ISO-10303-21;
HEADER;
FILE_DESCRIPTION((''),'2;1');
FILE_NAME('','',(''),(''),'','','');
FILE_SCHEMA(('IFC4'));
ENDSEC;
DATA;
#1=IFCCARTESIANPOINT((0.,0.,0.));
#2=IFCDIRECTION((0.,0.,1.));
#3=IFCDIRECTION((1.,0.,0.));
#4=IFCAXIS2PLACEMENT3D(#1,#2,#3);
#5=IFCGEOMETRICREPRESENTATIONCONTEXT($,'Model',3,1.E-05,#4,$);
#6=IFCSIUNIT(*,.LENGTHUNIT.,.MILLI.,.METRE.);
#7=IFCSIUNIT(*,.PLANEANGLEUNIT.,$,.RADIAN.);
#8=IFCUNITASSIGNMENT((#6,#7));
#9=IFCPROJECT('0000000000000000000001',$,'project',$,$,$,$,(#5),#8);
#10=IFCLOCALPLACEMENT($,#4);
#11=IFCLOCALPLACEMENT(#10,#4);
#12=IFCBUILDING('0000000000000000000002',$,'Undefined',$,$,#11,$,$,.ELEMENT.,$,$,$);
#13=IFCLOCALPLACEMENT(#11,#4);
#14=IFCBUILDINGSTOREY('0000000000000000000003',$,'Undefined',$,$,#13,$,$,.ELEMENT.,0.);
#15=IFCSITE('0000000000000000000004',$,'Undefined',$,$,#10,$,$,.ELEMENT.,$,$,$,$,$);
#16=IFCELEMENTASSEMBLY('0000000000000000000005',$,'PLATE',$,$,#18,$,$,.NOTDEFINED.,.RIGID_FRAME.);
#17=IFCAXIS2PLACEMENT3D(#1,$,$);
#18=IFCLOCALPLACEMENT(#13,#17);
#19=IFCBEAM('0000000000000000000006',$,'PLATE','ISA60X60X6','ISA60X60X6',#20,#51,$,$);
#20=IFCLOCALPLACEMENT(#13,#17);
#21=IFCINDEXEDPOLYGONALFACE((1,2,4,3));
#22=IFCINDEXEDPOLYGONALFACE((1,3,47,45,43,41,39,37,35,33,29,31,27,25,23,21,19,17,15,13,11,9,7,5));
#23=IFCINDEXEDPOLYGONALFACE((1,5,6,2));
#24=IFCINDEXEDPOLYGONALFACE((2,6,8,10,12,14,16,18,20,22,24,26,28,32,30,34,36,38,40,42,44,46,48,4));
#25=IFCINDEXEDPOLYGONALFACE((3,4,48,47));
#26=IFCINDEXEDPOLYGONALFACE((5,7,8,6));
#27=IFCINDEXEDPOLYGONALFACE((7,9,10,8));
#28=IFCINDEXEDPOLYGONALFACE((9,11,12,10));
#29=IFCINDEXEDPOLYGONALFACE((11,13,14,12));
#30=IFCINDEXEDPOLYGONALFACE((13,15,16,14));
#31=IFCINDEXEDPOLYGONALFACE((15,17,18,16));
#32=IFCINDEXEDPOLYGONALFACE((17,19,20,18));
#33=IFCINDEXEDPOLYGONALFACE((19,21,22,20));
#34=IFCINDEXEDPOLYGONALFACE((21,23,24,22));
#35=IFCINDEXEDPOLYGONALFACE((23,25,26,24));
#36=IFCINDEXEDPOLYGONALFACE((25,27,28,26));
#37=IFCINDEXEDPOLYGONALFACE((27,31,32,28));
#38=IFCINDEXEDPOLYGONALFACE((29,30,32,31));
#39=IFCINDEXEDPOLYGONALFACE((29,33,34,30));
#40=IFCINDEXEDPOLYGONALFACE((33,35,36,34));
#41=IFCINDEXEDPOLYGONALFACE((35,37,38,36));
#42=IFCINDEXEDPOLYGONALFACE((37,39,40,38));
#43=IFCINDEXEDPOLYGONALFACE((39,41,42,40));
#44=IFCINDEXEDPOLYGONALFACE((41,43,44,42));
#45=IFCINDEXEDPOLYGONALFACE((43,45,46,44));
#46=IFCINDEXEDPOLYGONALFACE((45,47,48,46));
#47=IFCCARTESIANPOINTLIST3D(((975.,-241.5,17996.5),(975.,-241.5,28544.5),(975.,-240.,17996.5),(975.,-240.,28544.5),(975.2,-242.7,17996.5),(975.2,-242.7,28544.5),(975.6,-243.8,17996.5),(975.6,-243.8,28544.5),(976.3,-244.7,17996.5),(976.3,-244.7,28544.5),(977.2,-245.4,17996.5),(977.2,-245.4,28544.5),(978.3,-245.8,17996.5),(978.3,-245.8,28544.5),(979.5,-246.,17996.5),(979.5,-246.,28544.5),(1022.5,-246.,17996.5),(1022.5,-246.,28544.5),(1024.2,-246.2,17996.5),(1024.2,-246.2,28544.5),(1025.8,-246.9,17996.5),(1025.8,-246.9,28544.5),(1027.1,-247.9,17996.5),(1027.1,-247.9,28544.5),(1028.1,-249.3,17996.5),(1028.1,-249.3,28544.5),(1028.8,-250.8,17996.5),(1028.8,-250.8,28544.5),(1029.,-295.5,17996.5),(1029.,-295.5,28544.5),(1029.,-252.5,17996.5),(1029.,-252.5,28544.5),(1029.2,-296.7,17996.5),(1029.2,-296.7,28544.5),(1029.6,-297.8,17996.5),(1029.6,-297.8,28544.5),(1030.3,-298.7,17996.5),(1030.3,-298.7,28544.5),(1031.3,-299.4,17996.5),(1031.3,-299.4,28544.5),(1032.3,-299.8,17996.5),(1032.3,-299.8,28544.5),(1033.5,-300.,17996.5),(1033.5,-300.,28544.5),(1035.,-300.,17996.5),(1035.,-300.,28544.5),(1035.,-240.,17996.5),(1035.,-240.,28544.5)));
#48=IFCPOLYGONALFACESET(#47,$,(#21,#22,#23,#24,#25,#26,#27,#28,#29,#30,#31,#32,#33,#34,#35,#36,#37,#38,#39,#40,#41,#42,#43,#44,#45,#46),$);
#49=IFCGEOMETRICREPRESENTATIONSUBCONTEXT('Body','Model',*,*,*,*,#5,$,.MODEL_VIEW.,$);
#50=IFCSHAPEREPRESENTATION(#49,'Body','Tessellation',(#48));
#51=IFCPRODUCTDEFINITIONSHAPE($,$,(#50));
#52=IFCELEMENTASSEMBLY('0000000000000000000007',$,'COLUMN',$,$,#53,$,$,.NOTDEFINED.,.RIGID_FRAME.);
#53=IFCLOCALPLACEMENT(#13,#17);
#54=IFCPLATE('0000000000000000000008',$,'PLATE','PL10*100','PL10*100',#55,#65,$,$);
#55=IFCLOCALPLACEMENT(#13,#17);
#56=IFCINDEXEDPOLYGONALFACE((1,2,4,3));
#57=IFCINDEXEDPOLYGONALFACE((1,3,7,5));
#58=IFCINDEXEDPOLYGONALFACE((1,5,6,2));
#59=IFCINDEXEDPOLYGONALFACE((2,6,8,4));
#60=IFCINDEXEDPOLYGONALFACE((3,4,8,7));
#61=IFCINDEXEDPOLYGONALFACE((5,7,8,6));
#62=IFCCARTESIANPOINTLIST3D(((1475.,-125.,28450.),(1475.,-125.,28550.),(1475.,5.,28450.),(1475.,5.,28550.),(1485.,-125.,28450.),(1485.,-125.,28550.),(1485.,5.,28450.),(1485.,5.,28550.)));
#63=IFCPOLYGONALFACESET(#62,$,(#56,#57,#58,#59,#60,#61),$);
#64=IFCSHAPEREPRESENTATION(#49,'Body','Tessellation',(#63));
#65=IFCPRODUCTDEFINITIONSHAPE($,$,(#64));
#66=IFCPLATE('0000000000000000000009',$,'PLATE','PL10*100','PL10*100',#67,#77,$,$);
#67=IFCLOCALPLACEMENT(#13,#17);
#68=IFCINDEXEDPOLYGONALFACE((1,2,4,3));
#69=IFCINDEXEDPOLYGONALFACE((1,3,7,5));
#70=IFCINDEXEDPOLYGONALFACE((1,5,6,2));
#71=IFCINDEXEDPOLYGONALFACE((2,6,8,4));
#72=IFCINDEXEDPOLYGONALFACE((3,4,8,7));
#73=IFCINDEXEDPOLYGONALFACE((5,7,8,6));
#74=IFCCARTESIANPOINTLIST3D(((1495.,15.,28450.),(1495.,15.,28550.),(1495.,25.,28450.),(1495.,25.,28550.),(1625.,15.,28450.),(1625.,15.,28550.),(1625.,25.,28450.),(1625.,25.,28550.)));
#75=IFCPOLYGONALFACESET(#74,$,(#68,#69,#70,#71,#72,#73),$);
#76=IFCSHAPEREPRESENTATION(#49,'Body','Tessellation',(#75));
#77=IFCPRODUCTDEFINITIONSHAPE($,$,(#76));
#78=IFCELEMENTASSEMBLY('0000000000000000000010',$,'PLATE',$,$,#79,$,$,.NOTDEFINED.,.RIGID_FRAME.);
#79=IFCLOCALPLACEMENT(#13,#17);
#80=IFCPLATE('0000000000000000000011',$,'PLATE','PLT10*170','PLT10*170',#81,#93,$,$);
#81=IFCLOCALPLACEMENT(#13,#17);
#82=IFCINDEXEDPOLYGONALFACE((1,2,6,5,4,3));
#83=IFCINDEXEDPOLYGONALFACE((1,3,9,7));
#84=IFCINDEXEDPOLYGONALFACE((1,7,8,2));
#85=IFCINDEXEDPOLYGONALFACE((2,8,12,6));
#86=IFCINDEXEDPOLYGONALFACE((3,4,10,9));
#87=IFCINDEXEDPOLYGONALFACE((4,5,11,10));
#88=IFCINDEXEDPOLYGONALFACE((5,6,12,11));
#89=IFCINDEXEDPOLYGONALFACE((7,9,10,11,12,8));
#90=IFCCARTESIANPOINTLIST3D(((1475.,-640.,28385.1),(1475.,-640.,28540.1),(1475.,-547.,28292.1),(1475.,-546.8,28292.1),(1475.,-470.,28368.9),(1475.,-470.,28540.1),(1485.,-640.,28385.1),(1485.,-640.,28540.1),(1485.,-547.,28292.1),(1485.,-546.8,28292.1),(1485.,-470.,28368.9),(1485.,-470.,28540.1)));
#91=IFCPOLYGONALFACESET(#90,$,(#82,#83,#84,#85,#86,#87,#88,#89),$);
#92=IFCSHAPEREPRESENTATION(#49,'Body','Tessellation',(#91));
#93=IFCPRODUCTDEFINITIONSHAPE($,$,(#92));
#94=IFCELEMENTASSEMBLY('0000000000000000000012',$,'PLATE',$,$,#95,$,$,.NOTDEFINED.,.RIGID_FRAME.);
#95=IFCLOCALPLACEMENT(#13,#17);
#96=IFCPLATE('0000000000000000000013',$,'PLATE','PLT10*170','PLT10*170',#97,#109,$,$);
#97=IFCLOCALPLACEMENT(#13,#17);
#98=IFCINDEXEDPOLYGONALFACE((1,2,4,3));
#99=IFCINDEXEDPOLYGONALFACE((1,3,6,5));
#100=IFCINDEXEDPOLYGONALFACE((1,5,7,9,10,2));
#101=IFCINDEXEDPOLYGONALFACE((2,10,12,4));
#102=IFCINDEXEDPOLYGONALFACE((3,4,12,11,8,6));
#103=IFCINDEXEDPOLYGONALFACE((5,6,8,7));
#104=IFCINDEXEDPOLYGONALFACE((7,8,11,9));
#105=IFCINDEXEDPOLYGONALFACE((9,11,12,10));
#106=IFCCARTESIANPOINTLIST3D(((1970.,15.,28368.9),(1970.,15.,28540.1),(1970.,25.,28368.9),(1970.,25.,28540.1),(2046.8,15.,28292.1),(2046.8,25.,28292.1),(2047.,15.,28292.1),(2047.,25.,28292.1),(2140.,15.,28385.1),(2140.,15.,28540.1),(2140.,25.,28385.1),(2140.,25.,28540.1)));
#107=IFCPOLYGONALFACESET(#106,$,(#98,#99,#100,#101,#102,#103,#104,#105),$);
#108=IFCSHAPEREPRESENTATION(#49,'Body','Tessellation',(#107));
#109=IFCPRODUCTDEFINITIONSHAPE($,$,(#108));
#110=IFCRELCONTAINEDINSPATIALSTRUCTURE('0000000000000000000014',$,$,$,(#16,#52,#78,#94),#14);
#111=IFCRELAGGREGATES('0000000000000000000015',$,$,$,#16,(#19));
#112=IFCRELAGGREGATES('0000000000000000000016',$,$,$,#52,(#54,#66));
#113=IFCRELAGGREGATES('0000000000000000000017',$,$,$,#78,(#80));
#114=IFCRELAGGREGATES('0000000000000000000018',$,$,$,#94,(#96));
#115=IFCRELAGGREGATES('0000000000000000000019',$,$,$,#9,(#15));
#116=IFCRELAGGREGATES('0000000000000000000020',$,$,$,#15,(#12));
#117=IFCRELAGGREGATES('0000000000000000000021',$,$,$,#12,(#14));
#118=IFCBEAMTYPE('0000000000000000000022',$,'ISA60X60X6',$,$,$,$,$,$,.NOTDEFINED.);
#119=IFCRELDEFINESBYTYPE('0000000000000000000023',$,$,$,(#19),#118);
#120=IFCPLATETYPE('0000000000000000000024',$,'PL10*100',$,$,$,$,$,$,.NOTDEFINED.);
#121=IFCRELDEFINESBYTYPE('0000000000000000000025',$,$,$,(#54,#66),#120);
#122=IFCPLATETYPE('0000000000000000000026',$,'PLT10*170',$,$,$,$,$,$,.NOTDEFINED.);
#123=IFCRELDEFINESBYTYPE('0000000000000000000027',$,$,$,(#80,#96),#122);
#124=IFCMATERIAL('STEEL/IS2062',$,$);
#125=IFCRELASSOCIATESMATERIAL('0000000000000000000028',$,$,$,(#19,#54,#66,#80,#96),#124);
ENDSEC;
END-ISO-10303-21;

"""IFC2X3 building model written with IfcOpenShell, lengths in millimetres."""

from ifc_helpers import new_model, si_unit, frame, origin_with_axes, origin_2d_with_axis, place, context, subcontext, project, spatial, polyline, l_section, outline, extrude, material, type_object, element, aggregate, save


model = new_model("IFC2X3")

# Units and contexts
model_context = context("Model", 3, precision=1e-05, world=origin_with_axes())
body_context = subcontext(model_context, "Body", "Model", "MODEL_VIEW")
ifc_project = project(units=[si_unit("LENGTHUNIT", "METRE", prefix="MILLI"), si_unit("PLANEANGLEUNIT", "RADIAN")], contexts=[model_context])

# Site, building, storey
site_placement = place(None, origin_with_axes())
site = spatial("IfcSite", under=ifc_project, at=site_placement, Name="Undefined", CompositionType="ELEMENT")
building_placement = place(site_placement, origin_with_axes())
building = spatial("IfcBuilding", under=site, at=building_placement, Name="Undefined", CompositionType="ELEMENT")
storey_placement = place(building_placement, origin_with_axes())
storey = spatial("IfcBuildingStorey", under=building, at=storey_placement, Name="Undefined", CompositionType="ELEMENT", Elevation=0.0)

# Shared definitions
ifc_material_1 = material(Name="STEEL/IS2062")

# Element assembly, beam
assembly_1_placement = place(storey_placement, origin_with_axes())
assembly_1 = element("IfcElementAssembly", 1, at=assembly_1_placement, inside=storey, Name="PLATE", AssemblyPlace="NOTDEFINED", PredefinedType="RIGID_FRAME")
beam_type_1 = type_object("IfcBeamType", Name="ISA60X60X6", PredefinedType="NOTDEFINED")
beam_1_placement = place(assembly_1_placement, frame((1005.0, -270.0, 28544.5), z_axis=(0.0, -1.0, 0.0), x_axis=(0.0, 0.0, -1.0)))
beam_1 = element("IfcBeam", 2, at=beam_1_placement, type_object=beam_type_1, material=ifc_material_1, Name="PLATE", Description="ISA60X60X6", ObjectType="ISA60X60X6", context=body_context, shape_type="SweptSolid", body=[
    extrude(l_section(Depth=60.0, Width=60.0, Thickness=6.0, FilletRadius=6.5, EdgeRadius=4.5, at=origin_2d_with_axis()), frame((10548.0, 0.0, 0.0), z_axis=(-1.0, 0.0, 0.0), x_axis=(0.0, -1.0, 0.0)), (0.0, 0.0, 1.0), 10548.0),
])
aggregate(assembly_1, [beam_1])

# Element assembly, plates
assembly_2_placement = place(storey_placement, origin_with_axes())
assembly_2 = element("IfcElementAssembly", 3, at=assembly_2_placement, inside=storey, Name="COLUMN", AssemblyPlace="NOTDEFINED", PredefinedType="RIGID_FRAME")
plate_type_1 = type_object("IfcPlateType", Name="PL10*100", PredefinedType="NOTDEFINED")
plate_1_placement = place(assembly_2_placement, frame((1480.0, 5.0, 28550.0), z_axis=(-1.0, 0.0, 0.0), x_axis=(0.0, 0.0, -1.0)))
plate_1 = element("IfcPlate", 4, at=plate_1_placement, type_object=plate_type_1, material=ifc_material_1, Name="PLATE", Description="PL10*100", ObjectType="PL10*100", context=body_context, shape_type="SweptSolid", body=[
    extrude(outline(polyline([(0.0, 0.0), (100.0, 0.0), (100.0, 130.0), (0.0, 130.0), (0.0, 0.0)])), frame((0.0, 0.0, -5.0), z_axis=(0.0, 0.0, 1.0), x_axis=(1.0, 0.0, 0.0)), (0.0, 0.0, 1.0), 10.0),
])
plate_2_placement = place(assembly_2_placement, frame((1495.0, 20.0, 28450.0), z_axis=(0.0, 1.0, 0.0), x_axis=(0.0, 0.0, 1.0)))
plate_2 = element("IfcPlate", 5, at=plate_2_placement, type_object=plate_type_1, material=ifc_material_1, Name="PLATE", Description="PL10*100", ObjectType="PL10*100", context=body_context, shape_type="SweptSolid", body=[
    extrude(outline(polyline([(0.0, 0.0), (100.0, 0.0), (100.0, 130.0), (0.0, 130.0), (0.0, 0.0)])), frame((0.0, 0.0, -5.0), z_axis=(0.0, 0.0, 1.0), x_axis=(1.0, 0.0, 0.0)), (0.0, 0.0, 1.0), 10.0),
])
aggregate(assembly_2, [plate_1, plate_2])

# Element assemblies, plates
assembly_3_placement = place(storey_placement, origin_with_axes())
assembly_3 = element("IfcElementAssembly", 6, at=assembly_3_placement, inside=storey, Name="PLATE", AssemblyPlace="NOTDEFINED", PredefinedType="RIGID_FRAME")
plate_type_2 = type_object("IfcPlateType", Name="PLT10*170", PredefinedType="NOTDEFINED")
plate_3_placement = place(assembly_3_placement, frame((1480.0, -640.0, 28540.1), z_axis=(1.0, 0.0, 0.0), x_axis=(0.0, 0.0, -1.0)))
plate_3 = element("IfcPlate", 7, at=plate_3_placement, type_object=plate_type_2, material=ifc_material_1, Name="PLATE", Description="PLT10*170", ObjectType="PLT10*170", context=body_context, shape_type="SweptSolid", body=[
    extrude(outline(polyline([(0.0, 0.0), (155.0, 0.0), (248.0, 93.0), (248.0, 93.2), (171.2, 170.0), (0.0, 170.0), (0.0, 0.0)])), frame((0.0, 0.0, -5.0), z_axis=(0.0, 0.0, 1.0), x_axis=(1.0, 0.0, 0.0)), (0.0, 0.0, 1.0), 10.0),
])
assembly_4_placement = place(storey_placement, origin_with_axes())
assembly_4 = element("IfcElementAssembly", 8, at=assembly_4_placement, inside=storey, Name="PLATE", AssemblyPlace="NOTDEFINED", PredefinedType="RIGID_FRAME")
plate_4_placement = place(assembly_4_placement, frame((2140.0, 20.0, 28540.1), z_axis=(0.0, 1.0, 0.0), x_axis=(0.0, 0.0, -1.0)))
plate_4 = element("IfcPlate", 9, at=plate_4_placement, type_object=plate_type_2, material=ifc_material_1, Name="PLATE", Description="PLT10*170", ObjectType="PLT10*170", context=body_context, shape_type="SweptSolid", body=[
    extrude(outline(polyline([(0.0, 0.0), (155.0, 0.0), (248.0, 93.0), (248.0, 93.2), (171.2, 170.0), (0.0, 170.0), (0.0, 0.0)])), frame((0.0, 0.0, -5.0), z_axis=(0.0, 0.0, 1.0), x_axis=(1.0, 0.0, 0.0)), (0.0, 0.0, 1.0), 10.0),
])

aggregate(assembly_3, [plate_3])
aggregate(assembly_4, [plate_4])

save(model, "model.ifc")
